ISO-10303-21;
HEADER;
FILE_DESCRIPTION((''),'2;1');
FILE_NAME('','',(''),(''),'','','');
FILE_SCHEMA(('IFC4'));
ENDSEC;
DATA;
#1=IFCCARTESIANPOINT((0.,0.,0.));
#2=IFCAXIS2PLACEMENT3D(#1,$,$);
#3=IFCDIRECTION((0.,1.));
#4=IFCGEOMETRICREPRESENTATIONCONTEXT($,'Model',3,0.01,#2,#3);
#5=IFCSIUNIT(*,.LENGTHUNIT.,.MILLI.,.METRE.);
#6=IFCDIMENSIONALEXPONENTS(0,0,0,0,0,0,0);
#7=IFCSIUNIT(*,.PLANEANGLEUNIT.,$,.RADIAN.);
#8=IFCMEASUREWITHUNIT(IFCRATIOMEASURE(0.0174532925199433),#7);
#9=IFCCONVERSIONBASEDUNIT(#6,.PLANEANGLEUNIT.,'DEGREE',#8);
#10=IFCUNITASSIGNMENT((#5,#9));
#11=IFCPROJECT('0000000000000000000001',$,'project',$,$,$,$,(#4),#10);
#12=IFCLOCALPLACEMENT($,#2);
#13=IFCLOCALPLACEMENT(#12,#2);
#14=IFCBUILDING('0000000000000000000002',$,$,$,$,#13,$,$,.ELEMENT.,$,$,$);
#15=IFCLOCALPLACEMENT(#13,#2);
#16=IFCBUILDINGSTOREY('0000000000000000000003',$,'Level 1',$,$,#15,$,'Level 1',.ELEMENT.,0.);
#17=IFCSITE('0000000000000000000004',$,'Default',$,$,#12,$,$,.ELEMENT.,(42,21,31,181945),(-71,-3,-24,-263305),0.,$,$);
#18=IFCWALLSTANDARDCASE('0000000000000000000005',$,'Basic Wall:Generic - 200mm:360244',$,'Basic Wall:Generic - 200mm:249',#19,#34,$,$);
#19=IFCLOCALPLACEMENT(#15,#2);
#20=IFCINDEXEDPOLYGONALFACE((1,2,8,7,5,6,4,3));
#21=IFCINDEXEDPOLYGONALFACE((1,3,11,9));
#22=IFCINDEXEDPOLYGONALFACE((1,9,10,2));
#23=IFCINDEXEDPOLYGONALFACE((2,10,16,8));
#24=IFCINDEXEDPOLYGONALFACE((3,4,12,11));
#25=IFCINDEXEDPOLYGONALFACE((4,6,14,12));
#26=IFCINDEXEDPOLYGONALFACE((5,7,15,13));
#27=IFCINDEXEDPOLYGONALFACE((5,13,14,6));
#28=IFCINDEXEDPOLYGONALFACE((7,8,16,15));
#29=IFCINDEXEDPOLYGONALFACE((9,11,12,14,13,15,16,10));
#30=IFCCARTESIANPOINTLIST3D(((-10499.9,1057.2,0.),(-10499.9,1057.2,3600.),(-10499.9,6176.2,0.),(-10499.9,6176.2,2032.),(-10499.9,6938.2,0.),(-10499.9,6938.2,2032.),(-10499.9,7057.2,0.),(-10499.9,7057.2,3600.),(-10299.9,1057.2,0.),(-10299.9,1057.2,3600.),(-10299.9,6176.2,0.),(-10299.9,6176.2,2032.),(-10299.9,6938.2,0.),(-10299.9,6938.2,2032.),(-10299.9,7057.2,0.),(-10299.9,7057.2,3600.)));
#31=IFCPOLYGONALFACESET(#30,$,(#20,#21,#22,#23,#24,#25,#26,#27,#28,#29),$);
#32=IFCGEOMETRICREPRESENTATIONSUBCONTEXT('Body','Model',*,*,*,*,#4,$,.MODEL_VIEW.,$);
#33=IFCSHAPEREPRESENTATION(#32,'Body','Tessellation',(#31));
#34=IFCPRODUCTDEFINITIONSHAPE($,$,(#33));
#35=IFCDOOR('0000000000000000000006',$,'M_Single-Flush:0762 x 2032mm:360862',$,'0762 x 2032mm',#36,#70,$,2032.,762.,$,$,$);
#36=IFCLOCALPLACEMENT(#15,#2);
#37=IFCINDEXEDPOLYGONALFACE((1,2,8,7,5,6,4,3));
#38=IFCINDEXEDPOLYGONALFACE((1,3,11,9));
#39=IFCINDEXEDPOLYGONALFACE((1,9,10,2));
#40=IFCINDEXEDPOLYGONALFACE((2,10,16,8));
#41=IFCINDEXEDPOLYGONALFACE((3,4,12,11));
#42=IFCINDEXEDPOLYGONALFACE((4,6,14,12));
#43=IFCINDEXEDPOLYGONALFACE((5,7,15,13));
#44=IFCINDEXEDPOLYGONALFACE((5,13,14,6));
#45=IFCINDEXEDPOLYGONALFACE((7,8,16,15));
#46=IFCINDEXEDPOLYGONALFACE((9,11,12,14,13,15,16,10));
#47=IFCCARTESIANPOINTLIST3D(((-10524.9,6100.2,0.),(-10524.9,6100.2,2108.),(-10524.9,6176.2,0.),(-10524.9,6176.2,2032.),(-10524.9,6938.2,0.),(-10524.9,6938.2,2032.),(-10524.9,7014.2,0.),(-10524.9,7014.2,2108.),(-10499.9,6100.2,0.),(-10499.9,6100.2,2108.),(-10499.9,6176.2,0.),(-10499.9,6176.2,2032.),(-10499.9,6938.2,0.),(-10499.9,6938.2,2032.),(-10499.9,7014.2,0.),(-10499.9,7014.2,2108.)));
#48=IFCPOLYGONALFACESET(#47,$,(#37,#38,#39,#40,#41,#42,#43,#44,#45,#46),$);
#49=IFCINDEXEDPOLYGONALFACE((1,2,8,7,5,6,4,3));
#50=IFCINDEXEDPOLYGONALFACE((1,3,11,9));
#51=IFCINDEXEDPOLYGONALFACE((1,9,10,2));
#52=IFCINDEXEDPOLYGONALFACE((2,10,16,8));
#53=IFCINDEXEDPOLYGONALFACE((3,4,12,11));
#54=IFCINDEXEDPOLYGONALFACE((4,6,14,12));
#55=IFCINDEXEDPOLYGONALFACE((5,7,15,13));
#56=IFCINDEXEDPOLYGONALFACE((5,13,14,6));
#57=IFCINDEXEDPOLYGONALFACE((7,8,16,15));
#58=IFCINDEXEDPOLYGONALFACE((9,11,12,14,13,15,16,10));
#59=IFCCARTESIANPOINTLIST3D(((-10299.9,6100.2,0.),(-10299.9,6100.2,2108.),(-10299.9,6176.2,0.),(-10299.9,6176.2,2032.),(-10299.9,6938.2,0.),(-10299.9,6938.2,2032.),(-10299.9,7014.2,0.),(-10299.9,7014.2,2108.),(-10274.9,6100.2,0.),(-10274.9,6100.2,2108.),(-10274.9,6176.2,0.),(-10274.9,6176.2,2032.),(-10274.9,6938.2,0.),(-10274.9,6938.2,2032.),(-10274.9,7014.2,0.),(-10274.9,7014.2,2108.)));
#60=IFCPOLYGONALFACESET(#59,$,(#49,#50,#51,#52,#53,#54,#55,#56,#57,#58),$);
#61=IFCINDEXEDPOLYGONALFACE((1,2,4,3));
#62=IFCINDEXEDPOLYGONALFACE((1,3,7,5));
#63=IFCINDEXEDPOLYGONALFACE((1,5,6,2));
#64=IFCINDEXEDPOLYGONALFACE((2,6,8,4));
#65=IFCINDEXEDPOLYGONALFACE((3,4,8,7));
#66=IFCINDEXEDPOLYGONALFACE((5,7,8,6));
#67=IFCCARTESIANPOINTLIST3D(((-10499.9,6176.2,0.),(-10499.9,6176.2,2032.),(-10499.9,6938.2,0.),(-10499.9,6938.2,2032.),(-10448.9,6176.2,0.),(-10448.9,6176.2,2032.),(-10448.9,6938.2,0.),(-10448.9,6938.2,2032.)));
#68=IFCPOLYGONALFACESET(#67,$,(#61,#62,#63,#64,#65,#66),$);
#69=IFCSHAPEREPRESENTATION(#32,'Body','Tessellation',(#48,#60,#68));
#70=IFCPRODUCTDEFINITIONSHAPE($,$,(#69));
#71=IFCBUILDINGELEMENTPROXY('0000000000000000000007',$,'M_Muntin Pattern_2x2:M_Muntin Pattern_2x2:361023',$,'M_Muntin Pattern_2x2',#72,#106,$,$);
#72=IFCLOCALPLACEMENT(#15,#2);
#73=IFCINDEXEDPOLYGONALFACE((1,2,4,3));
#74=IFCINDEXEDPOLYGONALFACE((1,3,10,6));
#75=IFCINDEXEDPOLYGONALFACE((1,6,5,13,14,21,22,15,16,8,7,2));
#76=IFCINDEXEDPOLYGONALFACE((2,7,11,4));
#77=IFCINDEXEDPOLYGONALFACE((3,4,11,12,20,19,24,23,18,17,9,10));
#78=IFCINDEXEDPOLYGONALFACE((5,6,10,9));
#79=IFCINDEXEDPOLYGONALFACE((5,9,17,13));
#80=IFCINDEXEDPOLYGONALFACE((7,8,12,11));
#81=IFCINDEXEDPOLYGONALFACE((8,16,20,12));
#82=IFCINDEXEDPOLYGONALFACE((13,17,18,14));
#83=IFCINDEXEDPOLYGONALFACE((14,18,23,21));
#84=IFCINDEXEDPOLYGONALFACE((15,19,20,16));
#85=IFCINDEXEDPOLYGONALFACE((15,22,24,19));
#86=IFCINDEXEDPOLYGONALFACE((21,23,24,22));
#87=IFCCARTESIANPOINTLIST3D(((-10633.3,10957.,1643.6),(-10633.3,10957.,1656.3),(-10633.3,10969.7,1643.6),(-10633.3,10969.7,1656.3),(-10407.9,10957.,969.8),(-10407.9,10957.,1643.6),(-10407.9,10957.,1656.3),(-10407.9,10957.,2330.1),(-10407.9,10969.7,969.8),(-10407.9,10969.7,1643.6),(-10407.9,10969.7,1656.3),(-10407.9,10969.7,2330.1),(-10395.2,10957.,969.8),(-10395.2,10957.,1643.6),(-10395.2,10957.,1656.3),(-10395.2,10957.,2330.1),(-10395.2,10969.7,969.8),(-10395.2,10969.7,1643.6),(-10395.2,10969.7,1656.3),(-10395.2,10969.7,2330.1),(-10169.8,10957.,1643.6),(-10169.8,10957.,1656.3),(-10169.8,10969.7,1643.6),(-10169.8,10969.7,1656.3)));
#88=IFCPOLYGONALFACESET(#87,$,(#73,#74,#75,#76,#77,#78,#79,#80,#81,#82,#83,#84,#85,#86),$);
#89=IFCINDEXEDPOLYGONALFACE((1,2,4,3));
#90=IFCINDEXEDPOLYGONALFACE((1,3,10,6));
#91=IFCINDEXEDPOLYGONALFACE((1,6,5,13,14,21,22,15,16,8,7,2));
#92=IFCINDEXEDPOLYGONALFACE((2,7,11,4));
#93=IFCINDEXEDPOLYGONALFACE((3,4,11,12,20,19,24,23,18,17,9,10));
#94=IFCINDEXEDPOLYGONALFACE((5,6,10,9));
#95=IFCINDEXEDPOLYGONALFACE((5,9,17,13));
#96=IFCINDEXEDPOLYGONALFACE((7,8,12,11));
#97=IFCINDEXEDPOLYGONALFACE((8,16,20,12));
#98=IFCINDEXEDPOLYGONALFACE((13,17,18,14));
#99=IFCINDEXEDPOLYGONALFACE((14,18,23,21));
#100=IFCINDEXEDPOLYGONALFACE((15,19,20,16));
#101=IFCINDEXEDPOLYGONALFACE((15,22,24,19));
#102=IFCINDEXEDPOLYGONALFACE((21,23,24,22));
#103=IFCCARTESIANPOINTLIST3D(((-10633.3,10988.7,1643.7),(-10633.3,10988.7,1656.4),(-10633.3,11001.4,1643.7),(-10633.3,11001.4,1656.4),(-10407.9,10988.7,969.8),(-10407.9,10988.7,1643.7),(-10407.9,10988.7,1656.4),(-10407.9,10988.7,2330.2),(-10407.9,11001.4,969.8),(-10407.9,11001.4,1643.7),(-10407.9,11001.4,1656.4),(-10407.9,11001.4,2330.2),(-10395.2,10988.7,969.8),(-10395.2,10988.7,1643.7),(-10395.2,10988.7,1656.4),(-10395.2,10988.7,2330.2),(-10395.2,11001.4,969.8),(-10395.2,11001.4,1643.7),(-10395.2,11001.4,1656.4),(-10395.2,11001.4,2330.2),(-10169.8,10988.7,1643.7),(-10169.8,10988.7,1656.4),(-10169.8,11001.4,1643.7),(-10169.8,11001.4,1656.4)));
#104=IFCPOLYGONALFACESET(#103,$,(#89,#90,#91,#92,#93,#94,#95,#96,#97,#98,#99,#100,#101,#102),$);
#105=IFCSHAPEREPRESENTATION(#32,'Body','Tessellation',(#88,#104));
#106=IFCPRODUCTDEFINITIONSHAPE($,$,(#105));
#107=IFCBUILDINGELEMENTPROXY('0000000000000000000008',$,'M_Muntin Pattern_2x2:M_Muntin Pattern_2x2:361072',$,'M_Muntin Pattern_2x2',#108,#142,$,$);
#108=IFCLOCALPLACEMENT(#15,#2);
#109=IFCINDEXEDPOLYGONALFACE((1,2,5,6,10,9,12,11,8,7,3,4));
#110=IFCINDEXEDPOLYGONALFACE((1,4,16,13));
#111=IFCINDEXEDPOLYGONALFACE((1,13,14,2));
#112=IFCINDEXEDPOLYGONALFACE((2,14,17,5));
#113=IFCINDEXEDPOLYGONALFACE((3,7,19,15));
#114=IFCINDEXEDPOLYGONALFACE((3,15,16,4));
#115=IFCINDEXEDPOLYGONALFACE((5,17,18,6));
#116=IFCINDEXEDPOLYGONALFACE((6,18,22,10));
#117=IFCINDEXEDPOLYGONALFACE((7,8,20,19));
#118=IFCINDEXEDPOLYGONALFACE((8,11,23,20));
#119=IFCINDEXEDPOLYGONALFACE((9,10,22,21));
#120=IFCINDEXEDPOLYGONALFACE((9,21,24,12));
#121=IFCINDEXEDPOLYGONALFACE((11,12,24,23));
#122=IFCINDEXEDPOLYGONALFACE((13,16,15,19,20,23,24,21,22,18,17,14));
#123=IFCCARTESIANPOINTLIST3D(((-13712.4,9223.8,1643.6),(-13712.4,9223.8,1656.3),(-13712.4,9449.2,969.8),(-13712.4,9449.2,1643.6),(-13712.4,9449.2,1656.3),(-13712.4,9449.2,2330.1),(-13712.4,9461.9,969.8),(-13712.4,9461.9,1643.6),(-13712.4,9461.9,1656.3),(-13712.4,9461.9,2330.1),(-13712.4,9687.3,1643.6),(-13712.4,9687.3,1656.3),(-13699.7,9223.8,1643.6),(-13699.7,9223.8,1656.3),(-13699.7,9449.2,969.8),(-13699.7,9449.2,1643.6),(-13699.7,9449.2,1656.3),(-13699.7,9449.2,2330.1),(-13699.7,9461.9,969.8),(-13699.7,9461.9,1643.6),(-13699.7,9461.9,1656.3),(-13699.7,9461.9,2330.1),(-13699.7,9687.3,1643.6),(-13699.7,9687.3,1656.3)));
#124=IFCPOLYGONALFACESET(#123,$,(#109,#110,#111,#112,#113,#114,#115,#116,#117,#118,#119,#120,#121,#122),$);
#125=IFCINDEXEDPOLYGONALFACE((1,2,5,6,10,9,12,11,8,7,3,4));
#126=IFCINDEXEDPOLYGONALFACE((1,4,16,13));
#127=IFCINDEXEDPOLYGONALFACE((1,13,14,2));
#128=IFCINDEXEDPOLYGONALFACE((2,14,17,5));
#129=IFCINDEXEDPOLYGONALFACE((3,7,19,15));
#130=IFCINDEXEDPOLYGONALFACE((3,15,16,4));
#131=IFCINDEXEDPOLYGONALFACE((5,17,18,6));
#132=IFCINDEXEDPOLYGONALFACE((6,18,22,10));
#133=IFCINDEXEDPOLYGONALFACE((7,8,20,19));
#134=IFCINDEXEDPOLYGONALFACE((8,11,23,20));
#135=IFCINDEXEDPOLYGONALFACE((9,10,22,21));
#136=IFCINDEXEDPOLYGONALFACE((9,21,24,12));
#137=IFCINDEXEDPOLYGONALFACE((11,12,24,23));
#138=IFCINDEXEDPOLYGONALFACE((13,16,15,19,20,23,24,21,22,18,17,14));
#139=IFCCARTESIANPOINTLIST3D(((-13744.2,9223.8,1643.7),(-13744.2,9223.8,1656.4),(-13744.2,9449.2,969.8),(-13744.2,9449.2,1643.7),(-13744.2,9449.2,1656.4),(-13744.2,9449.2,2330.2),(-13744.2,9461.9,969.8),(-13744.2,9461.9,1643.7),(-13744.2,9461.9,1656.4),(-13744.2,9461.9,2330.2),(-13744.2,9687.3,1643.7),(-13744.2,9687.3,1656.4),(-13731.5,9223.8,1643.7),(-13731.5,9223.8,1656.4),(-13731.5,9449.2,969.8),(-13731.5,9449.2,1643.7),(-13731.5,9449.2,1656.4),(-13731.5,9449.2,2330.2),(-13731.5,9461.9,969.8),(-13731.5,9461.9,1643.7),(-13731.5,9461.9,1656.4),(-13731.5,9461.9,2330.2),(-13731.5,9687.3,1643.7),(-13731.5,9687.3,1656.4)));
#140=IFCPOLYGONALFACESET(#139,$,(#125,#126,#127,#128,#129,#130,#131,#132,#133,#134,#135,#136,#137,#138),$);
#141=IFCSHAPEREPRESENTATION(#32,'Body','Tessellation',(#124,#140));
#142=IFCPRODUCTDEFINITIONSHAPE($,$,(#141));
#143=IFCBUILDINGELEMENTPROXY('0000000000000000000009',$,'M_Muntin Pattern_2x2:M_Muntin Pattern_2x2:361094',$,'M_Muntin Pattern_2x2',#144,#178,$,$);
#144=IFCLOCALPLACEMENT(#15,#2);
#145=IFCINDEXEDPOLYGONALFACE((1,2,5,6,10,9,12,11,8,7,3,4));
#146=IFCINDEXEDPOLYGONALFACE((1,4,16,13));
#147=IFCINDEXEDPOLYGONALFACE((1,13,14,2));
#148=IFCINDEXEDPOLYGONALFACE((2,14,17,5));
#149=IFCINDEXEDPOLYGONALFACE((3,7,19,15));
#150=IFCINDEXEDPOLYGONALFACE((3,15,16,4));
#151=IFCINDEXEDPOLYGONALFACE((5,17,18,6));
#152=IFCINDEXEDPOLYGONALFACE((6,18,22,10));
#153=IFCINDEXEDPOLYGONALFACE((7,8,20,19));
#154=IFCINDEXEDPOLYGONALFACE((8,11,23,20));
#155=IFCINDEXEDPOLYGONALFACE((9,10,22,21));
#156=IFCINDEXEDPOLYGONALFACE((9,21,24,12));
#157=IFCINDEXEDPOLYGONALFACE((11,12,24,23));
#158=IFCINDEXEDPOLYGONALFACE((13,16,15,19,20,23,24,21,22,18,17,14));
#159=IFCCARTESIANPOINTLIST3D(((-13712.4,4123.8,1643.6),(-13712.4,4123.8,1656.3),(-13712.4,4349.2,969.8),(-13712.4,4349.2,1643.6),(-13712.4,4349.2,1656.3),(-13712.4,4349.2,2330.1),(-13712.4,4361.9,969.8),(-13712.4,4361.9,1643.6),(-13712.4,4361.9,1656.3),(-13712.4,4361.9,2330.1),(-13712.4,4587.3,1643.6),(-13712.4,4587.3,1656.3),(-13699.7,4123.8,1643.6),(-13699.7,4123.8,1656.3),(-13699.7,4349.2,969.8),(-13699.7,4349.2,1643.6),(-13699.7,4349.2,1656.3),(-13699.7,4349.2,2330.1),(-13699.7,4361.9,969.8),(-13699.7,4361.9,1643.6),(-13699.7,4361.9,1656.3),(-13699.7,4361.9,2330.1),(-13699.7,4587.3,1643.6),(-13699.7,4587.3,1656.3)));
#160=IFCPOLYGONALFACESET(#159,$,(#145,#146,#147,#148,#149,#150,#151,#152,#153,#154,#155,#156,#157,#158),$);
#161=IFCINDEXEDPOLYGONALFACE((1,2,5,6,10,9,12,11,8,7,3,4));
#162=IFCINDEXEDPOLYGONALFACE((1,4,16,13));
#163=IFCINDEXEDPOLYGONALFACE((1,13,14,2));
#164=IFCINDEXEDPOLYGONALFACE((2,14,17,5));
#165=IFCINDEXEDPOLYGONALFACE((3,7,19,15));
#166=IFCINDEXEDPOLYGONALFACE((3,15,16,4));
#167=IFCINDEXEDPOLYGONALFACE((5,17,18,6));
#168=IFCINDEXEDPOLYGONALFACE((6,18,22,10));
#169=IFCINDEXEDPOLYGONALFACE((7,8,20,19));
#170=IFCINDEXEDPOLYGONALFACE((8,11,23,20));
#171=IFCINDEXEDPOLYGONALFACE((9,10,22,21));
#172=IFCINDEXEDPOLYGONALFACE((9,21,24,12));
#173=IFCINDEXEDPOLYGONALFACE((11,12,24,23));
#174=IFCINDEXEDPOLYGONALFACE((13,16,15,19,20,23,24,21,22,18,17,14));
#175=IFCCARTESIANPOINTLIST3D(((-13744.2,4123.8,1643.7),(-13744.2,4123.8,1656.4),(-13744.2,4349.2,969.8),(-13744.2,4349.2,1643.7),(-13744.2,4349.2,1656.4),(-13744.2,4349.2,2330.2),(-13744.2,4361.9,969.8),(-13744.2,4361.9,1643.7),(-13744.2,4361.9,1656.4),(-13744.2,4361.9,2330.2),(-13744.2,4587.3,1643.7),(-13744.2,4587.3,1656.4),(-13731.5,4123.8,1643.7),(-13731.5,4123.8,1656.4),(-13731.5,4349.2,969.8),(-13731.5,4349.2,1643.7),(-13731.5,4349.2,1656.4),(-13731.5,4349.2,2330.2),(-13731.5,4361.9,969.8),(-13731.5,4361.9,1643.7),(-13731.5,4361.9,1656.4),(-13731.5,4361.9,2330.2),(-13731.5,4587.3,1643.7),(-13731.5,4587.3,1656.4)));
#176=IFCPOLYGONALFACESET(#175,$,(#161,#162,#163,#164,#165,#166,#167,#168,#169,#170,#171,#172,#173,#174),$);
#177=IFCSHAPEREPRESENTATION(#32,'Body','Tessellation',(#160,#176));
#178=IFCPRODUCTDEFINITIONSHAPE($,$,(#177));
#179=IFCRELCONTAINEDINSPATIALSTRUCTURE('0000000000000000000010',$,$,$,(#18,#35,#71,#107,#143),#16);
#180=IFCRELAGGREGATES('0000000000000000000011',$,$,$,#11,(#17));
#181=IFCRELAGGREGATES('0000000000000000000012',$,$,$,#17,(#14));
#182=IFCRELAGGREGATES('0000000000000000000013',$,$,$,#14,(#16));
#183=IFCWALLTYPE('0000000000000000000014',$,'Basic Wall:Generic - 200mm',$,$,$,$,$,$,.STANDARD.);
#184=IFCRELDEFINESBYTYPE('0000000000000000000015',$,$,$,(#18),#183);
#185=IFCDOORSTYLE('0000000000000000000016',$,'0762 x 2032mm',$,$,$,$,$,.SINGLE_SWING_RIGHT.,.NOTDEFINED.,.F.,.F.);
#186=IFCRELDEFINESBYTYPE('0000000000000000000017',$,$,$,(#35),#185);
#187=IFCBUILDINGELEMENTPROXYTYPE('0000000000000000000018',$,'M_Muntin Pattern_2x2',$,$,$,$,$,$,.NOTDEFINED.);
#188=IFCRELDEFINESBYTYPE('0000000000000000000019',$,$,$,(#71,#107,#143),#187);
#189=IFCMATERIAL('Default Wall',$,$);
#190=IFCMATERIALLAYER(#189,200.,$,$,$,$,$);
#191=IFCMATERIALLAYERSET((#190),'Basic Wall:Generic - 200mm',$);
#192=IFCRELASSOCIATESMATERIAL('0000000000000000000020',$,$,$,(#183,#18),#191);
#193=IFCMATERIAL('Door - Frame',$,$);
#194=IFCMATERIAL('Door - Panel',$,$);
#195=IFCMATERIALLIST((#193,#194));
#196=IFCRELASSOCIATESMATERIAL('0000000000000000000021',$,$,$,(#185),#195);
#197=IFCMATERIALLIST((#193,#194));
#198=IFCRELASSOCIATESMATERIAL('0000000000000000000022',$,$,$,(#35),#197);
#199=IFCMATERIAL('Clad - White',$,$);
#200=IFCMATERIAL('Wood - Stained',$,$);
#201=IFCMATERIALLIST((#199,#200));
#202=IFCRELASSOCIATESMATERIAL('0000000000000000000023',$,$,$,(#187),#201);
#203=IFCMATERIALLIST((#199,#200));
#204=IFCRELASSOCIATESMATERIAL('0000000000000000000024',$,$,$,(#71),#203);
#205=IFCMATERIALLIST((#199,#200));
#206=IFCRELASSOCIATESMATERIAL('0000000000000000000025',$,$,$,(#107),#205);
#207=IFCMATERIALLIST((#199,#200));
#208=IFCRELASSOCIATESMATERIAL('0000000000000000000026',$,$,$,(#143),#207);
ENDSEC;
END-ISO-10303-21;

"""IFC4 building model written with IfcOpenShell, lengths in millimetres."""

from ifc_helpers import new_model, entity, si_unit, converted_unit, direction, frame, frame_2d, origin, place, context, subcontext, project, spatial, polyline, rectangle, outline, extrude, clip, bounded_halfspace, source, transform, mapped, material, material_list, layer, layer_set, layer_usage, type_object, type_shapes, element, fill, save


model = new_model("IFC4")

# Units and contexts
model_context = context("Model", 3, precision=0.01, world=origin(), true_north=direction((0.0, 1.0)))
body_context = subcontext(model_context, "Body", "Model", "MODEL_VIEW")
ifc_project = project(units=[si_unit("LENGTHUNIT", "METRE", prefix="MILLI"), converted_unit("PLANEANGLEUNIT", "DEGREE", entity("IfcRatioMeasure", 0.0174532925199433), si_unit("PLANEANGLEUNIT", "RADIAN"), dimensions=[0, 0, 0, 0, 0, 0, 0])], contexts=[model_context])

# Site, building, storey
site_placement = place(None, origin())
site = spatial("IfcSite", under=ifc_project, at=site_placement, Name="Default", CompositionType="ELEMENT", RefLatitude=(42, 21, 31, 181945), RefLongitude=(-71, -3, -24, -263305), RefElevation=0.0)
building_placement = place(site_placement, origin())
building = spatial("IfcBuilding", under=site, at=building_placement, CompositionType="ELEMENT")
storey_placement = place(building_placement, origin())
storey = spatial("IfcBuildingStorey", under=building, at=storey_placement, Name="Level 1", LongName="Level 1", CompositionType="ELEMENT", Elevation=0.0)

# Shared definitions
ifc_material_1 = material(Name="Default Wall")

# Shared definitions
ifc_layer_1 = layer(ifc_material_1, 200.0)
ifc_layer_set_1 = layer_set([ifc_layer_1], Name="Basic Wall:Generic - 200mm")
wall_type_1 = type_object("IfcWallType", Name="Basic Wall:Generic - 200mm", PredefinedType="STANDARD", material=ifc_layer_set_1)
ifc_material_2 = material(Name="Door - Frame")
ifc_material_3 = material(Name="Door - Panel")
ifc_material_list_1 = material_list([ifc_material_2, ifc_material_3])
door_style_1 = type_object("IfcDoorStyle", Name="0762 x 2032mm", ConstructionType="NOTDEFINED", OperationType="SINGLE_SWING_RIGHT", ParameterTakesPrecedence=False, Sizeable=False, material=ifc_material_list_1)
shared_shape_1 = source(origin(), body_context, "Body", "SweptSolid", [
    extrude(outline(polyline([(-457.0, -1073.0), (457.0, -1073.0), (457.0, 1035.0), (381.0, 1035.0), (381.0, -997.0), (-381.0, -997.0), (-381.0, 1035.0), (-457.0, 1035.0), (-457.0, -1073.0)])), frame((381.0, 200.0, 1035.0), z_axis=(0.0, 1.0, 0.0), x_axis=(1.0, 0.0, 0.0)), (0.0, 0.0, 1.0), 25.0),
    extrude(outline(polyline([(-1073.0, -457.0), (1035.0, -457.0), (1035.0, -381.0), (-997.0, -381.0), (-997.0, 381.0), (1035.0, 381.0), (1035.0, 457.0), (-1073.0, 457.0), (-1073.0, -457.0)])), frame((381.0, -25.0, 1035.0), z_axis=(0.0, 1.0, 0.0), x_axis=(0.0, 0.0, -1.0)), (0.0, 0.0, 1.0), 25.0),
    extrude(rectangle(XDim=51.0, YDim=762.0, at=frame_2d((0.0, 0.0), x_axis=(1.0, 0.0))), frame((381.0, 174.5, 0.0), z_axis=(0.0, 0.0, 1.0), x_axis=(0.0, 1.0, 0.0)), (0.0, 0.0, 1.0), 2032.0),
])
type_shapes(door_style_1, [shared_shape_1])

# Wall, opening, door
ifc_layer_usage_1 = layer_usage(ifc_layer_set_1, "AXIS2", "NEGATIVE", 100.0)
wall_1_placement = place(storey_placement, frame((-10399.9, 7057.2, 0.0), z_axis=(0.0, 0.0, 1.0), x_axis=(0.0, -1.0, 0.0)))
wall_1 = element("IfcWallStandardCase", 1, at=wall_1_placement, inside=storey, type_object=wall_type_1, material=ifc_layer_usage_1, Name="Basic Wall:Generic - 200mm:360244", ObjectType="Basic Wall:Generic - 200mm:249", context=body_context, shape_type="Clipping", body=[
    clip(extrude(rectangle(XDim=6000.0, YDim=200.0, at=frame_2d((3000.0, 0.0), x_axis=(-1.0, 0.0))), origin(), (0.0, 0.0, 1.0), 3600.0), bounded_halfspace(frame((0.0, -100.0, 3600.0), z_axis=(0.0, 0.0, -1.0), x_axis=(0.0, 1.0, 0.0)), True, frame((0.0, -100.0, 3600.0)), polyline([(0.0, 0.0), (6000.0, 0.0), (6000.0, 200.0), (0.0, 200.0), (0.0, 0.0)]))),
])
opening_1_placement = place(wall_1_placement, frame((881.0, 100.0, 0.0)))
opening_1 = element("IfcOpeningElement", 2, at=opening_1_placement, cuts=wall_1, ObjectType="Opening", context=body_context, shape_type="SweptSolid", body=[
    extrude(rectangle(XDim=762.0, YDim=2032.0, at=frame_2d((1016.0, 381.0), x_axis=(0.0, 1.0))), frame((0.0, 0.0, 0.0), z_axis=(0.0, -1.0, 0.0), x_axis=(0.0, 0.0, 1.0)), (0.0, 0.0, 1.0), 200.0),
])
ifc_material_list_2 = material_list([ifc_material_2, ifc_material_3])
door_1_placement = place(opening_1_placement, frame((0.0, 0.0, 0.0), z_axis=(0.0, 0.0, 1.0), x_axis=(-1.0, 0.0, 0.0)))
door_1 = element("IfcDoor", 3, at=door_1_placement, inside=storey, type_object=door_style_1, material=ifc_material_list_2, Name="M_Single-Flush:0762 x 2032mm:360862", ObjectType="0762 x 2032mm", OverallHeight=2032.0, OverallWidth=762.0, context=body_context, shape_type="MappedRepresentation", body=[
    mapped(shared_shape_1, transform((0.0, 0.0, 0.0), scale=1.0)),
])
fill(opening_1, door_1)

# Building element proxies
ifc_material_4 = material(Name="Clad - White")
ifc_material_5 = material(Name="Wood - Stained")
ifc_material_list_3 = material_list([ifc_material_4, ifc_material_5])
ifc_material_list_4 = material_list([ifc_material_4, ifc_material_5])
building_element_proxy_type_1 = type_object("IfcBuildingElementProxyType", Name="M_Muntin Pattern_2x2", PredefinedType="NOTDEFINED", material=ifc_material_list_4)
shared_shape_2 = source(origin(), body_context, "Body", "SweptSolid", [
    extrude(outline(polyline([(6.4, -6.4), (680.1, -6.4), (680.1, 6.3), (6.4, 6.3), (6.4, 231.7), (-6.3, 231.7), (-6.3, 6.3), (-680.2, 6.3), (-680.2, -6.4), (-6.3, -6.4), (-6.3, -231.7), (6.4, -231.7), (6.4, -6.4)])), frame((0.0, 9.5, 680.1), z_axis=(0.0, 1.0, 0.0), x_axis=(0.0, 0.0, 1.0)), (0.0, 0.0, 1.0), 12.7),
    extrude(outline(polyline([(6.4, -6.4), (680.2, -6.4), (680.2, 6.3), (6.4, 6.3), (6.4, 231.7), (-6.3, 231.7), (-6.3, 6.3), (-680.2, 6.3), (-680.2, -6.4), (-6.3, -6.4), (-6.3, -231.7), (6.4, -231.7), (6.4, -6.4)])), frame((0.0, -22.2, 680.2), z_axis=(0.0, 1.0, 0.0), x_axis=(0.0, 0.0, 1.0)), (0.0, 0.0, 1.0), 12.7),
])
type_shapes(building_element_proxy_type_1, [shared_shape_2])
proxy_1_placement = place(storey_placement, frame((-10401.5, 10979.2, 969.8), z_axis=(0.0, 0.0, 1.0), x_axis=(-1.0, 0.0, 0.0)))
element("IfcBuildingElementProxy", 4, at=proxy_1_placement, inside=storey, type_object=building_element_proxy_type_1, material=ifc_material_list_3, Name="M_Muntin Pattern_2x2:M_Muntin Pattern_2x2:361023", ObjectType="M_Muntin Pattern_2x2", context=body_context, shape_type="MappedRepresentation", body=[
    mapped(shared_shape_2, transform((0.0, 0.0, 0.0), scale=1.0)),
])
ifc_material_list_5 = material_list([ifc_material_4, ifc_material_5])
proxy_2_placement = place(storey_placement, frame((-13722.0, 9455.6, 969.8), z_axis=(0.0, 0.0, 1.0), x_axis=(0.0, -1.0, 0.0)))
element("IfcBuildingElementProxy", 5, at=proxy_2_placement, inside=storey, type_object=building_element_proxy_type_1, material=ifc_material_list_5, Name="M_Muntin Pattern_2x2:M_Muntin Pattern_2x2:361072", ObjectType="M_Muntin Pattern_2x2", context=body_context, shape_type="MappedRepresentation", body=[
    mapped(shared_shape_2, transform((0.0, 0.0, 0.0), scale=1.0)),
])
ifc_material_list_6 = material_list([ifc_material_4, ifc_material_5])
proxy_3_placement = place(storey_placement, frame((-13722.0, 4355.6, 969.8), z_axis=(0.0, 0.0, 1.0), x_axis=(0.0, -1.0, 0.0)))
element("IfcBuildingElementProxy", 6, at=proxy_3_placement, inside=storey, type_object=building_element_proxy_type_1, material=ifc_material_list_6, Name="M_Muntin Pattern_2x2:M_Muntin Pattern_2x2:361094", ObjectType="M_Muntin Pattern_2x2", context=body_context, shape_type="MappedRepresentation", body=[
    mapped(shared_shape_2, transform((0.0, 0.0, 0.0), scale=1.0)),
])

save(model, "model.ifc")
